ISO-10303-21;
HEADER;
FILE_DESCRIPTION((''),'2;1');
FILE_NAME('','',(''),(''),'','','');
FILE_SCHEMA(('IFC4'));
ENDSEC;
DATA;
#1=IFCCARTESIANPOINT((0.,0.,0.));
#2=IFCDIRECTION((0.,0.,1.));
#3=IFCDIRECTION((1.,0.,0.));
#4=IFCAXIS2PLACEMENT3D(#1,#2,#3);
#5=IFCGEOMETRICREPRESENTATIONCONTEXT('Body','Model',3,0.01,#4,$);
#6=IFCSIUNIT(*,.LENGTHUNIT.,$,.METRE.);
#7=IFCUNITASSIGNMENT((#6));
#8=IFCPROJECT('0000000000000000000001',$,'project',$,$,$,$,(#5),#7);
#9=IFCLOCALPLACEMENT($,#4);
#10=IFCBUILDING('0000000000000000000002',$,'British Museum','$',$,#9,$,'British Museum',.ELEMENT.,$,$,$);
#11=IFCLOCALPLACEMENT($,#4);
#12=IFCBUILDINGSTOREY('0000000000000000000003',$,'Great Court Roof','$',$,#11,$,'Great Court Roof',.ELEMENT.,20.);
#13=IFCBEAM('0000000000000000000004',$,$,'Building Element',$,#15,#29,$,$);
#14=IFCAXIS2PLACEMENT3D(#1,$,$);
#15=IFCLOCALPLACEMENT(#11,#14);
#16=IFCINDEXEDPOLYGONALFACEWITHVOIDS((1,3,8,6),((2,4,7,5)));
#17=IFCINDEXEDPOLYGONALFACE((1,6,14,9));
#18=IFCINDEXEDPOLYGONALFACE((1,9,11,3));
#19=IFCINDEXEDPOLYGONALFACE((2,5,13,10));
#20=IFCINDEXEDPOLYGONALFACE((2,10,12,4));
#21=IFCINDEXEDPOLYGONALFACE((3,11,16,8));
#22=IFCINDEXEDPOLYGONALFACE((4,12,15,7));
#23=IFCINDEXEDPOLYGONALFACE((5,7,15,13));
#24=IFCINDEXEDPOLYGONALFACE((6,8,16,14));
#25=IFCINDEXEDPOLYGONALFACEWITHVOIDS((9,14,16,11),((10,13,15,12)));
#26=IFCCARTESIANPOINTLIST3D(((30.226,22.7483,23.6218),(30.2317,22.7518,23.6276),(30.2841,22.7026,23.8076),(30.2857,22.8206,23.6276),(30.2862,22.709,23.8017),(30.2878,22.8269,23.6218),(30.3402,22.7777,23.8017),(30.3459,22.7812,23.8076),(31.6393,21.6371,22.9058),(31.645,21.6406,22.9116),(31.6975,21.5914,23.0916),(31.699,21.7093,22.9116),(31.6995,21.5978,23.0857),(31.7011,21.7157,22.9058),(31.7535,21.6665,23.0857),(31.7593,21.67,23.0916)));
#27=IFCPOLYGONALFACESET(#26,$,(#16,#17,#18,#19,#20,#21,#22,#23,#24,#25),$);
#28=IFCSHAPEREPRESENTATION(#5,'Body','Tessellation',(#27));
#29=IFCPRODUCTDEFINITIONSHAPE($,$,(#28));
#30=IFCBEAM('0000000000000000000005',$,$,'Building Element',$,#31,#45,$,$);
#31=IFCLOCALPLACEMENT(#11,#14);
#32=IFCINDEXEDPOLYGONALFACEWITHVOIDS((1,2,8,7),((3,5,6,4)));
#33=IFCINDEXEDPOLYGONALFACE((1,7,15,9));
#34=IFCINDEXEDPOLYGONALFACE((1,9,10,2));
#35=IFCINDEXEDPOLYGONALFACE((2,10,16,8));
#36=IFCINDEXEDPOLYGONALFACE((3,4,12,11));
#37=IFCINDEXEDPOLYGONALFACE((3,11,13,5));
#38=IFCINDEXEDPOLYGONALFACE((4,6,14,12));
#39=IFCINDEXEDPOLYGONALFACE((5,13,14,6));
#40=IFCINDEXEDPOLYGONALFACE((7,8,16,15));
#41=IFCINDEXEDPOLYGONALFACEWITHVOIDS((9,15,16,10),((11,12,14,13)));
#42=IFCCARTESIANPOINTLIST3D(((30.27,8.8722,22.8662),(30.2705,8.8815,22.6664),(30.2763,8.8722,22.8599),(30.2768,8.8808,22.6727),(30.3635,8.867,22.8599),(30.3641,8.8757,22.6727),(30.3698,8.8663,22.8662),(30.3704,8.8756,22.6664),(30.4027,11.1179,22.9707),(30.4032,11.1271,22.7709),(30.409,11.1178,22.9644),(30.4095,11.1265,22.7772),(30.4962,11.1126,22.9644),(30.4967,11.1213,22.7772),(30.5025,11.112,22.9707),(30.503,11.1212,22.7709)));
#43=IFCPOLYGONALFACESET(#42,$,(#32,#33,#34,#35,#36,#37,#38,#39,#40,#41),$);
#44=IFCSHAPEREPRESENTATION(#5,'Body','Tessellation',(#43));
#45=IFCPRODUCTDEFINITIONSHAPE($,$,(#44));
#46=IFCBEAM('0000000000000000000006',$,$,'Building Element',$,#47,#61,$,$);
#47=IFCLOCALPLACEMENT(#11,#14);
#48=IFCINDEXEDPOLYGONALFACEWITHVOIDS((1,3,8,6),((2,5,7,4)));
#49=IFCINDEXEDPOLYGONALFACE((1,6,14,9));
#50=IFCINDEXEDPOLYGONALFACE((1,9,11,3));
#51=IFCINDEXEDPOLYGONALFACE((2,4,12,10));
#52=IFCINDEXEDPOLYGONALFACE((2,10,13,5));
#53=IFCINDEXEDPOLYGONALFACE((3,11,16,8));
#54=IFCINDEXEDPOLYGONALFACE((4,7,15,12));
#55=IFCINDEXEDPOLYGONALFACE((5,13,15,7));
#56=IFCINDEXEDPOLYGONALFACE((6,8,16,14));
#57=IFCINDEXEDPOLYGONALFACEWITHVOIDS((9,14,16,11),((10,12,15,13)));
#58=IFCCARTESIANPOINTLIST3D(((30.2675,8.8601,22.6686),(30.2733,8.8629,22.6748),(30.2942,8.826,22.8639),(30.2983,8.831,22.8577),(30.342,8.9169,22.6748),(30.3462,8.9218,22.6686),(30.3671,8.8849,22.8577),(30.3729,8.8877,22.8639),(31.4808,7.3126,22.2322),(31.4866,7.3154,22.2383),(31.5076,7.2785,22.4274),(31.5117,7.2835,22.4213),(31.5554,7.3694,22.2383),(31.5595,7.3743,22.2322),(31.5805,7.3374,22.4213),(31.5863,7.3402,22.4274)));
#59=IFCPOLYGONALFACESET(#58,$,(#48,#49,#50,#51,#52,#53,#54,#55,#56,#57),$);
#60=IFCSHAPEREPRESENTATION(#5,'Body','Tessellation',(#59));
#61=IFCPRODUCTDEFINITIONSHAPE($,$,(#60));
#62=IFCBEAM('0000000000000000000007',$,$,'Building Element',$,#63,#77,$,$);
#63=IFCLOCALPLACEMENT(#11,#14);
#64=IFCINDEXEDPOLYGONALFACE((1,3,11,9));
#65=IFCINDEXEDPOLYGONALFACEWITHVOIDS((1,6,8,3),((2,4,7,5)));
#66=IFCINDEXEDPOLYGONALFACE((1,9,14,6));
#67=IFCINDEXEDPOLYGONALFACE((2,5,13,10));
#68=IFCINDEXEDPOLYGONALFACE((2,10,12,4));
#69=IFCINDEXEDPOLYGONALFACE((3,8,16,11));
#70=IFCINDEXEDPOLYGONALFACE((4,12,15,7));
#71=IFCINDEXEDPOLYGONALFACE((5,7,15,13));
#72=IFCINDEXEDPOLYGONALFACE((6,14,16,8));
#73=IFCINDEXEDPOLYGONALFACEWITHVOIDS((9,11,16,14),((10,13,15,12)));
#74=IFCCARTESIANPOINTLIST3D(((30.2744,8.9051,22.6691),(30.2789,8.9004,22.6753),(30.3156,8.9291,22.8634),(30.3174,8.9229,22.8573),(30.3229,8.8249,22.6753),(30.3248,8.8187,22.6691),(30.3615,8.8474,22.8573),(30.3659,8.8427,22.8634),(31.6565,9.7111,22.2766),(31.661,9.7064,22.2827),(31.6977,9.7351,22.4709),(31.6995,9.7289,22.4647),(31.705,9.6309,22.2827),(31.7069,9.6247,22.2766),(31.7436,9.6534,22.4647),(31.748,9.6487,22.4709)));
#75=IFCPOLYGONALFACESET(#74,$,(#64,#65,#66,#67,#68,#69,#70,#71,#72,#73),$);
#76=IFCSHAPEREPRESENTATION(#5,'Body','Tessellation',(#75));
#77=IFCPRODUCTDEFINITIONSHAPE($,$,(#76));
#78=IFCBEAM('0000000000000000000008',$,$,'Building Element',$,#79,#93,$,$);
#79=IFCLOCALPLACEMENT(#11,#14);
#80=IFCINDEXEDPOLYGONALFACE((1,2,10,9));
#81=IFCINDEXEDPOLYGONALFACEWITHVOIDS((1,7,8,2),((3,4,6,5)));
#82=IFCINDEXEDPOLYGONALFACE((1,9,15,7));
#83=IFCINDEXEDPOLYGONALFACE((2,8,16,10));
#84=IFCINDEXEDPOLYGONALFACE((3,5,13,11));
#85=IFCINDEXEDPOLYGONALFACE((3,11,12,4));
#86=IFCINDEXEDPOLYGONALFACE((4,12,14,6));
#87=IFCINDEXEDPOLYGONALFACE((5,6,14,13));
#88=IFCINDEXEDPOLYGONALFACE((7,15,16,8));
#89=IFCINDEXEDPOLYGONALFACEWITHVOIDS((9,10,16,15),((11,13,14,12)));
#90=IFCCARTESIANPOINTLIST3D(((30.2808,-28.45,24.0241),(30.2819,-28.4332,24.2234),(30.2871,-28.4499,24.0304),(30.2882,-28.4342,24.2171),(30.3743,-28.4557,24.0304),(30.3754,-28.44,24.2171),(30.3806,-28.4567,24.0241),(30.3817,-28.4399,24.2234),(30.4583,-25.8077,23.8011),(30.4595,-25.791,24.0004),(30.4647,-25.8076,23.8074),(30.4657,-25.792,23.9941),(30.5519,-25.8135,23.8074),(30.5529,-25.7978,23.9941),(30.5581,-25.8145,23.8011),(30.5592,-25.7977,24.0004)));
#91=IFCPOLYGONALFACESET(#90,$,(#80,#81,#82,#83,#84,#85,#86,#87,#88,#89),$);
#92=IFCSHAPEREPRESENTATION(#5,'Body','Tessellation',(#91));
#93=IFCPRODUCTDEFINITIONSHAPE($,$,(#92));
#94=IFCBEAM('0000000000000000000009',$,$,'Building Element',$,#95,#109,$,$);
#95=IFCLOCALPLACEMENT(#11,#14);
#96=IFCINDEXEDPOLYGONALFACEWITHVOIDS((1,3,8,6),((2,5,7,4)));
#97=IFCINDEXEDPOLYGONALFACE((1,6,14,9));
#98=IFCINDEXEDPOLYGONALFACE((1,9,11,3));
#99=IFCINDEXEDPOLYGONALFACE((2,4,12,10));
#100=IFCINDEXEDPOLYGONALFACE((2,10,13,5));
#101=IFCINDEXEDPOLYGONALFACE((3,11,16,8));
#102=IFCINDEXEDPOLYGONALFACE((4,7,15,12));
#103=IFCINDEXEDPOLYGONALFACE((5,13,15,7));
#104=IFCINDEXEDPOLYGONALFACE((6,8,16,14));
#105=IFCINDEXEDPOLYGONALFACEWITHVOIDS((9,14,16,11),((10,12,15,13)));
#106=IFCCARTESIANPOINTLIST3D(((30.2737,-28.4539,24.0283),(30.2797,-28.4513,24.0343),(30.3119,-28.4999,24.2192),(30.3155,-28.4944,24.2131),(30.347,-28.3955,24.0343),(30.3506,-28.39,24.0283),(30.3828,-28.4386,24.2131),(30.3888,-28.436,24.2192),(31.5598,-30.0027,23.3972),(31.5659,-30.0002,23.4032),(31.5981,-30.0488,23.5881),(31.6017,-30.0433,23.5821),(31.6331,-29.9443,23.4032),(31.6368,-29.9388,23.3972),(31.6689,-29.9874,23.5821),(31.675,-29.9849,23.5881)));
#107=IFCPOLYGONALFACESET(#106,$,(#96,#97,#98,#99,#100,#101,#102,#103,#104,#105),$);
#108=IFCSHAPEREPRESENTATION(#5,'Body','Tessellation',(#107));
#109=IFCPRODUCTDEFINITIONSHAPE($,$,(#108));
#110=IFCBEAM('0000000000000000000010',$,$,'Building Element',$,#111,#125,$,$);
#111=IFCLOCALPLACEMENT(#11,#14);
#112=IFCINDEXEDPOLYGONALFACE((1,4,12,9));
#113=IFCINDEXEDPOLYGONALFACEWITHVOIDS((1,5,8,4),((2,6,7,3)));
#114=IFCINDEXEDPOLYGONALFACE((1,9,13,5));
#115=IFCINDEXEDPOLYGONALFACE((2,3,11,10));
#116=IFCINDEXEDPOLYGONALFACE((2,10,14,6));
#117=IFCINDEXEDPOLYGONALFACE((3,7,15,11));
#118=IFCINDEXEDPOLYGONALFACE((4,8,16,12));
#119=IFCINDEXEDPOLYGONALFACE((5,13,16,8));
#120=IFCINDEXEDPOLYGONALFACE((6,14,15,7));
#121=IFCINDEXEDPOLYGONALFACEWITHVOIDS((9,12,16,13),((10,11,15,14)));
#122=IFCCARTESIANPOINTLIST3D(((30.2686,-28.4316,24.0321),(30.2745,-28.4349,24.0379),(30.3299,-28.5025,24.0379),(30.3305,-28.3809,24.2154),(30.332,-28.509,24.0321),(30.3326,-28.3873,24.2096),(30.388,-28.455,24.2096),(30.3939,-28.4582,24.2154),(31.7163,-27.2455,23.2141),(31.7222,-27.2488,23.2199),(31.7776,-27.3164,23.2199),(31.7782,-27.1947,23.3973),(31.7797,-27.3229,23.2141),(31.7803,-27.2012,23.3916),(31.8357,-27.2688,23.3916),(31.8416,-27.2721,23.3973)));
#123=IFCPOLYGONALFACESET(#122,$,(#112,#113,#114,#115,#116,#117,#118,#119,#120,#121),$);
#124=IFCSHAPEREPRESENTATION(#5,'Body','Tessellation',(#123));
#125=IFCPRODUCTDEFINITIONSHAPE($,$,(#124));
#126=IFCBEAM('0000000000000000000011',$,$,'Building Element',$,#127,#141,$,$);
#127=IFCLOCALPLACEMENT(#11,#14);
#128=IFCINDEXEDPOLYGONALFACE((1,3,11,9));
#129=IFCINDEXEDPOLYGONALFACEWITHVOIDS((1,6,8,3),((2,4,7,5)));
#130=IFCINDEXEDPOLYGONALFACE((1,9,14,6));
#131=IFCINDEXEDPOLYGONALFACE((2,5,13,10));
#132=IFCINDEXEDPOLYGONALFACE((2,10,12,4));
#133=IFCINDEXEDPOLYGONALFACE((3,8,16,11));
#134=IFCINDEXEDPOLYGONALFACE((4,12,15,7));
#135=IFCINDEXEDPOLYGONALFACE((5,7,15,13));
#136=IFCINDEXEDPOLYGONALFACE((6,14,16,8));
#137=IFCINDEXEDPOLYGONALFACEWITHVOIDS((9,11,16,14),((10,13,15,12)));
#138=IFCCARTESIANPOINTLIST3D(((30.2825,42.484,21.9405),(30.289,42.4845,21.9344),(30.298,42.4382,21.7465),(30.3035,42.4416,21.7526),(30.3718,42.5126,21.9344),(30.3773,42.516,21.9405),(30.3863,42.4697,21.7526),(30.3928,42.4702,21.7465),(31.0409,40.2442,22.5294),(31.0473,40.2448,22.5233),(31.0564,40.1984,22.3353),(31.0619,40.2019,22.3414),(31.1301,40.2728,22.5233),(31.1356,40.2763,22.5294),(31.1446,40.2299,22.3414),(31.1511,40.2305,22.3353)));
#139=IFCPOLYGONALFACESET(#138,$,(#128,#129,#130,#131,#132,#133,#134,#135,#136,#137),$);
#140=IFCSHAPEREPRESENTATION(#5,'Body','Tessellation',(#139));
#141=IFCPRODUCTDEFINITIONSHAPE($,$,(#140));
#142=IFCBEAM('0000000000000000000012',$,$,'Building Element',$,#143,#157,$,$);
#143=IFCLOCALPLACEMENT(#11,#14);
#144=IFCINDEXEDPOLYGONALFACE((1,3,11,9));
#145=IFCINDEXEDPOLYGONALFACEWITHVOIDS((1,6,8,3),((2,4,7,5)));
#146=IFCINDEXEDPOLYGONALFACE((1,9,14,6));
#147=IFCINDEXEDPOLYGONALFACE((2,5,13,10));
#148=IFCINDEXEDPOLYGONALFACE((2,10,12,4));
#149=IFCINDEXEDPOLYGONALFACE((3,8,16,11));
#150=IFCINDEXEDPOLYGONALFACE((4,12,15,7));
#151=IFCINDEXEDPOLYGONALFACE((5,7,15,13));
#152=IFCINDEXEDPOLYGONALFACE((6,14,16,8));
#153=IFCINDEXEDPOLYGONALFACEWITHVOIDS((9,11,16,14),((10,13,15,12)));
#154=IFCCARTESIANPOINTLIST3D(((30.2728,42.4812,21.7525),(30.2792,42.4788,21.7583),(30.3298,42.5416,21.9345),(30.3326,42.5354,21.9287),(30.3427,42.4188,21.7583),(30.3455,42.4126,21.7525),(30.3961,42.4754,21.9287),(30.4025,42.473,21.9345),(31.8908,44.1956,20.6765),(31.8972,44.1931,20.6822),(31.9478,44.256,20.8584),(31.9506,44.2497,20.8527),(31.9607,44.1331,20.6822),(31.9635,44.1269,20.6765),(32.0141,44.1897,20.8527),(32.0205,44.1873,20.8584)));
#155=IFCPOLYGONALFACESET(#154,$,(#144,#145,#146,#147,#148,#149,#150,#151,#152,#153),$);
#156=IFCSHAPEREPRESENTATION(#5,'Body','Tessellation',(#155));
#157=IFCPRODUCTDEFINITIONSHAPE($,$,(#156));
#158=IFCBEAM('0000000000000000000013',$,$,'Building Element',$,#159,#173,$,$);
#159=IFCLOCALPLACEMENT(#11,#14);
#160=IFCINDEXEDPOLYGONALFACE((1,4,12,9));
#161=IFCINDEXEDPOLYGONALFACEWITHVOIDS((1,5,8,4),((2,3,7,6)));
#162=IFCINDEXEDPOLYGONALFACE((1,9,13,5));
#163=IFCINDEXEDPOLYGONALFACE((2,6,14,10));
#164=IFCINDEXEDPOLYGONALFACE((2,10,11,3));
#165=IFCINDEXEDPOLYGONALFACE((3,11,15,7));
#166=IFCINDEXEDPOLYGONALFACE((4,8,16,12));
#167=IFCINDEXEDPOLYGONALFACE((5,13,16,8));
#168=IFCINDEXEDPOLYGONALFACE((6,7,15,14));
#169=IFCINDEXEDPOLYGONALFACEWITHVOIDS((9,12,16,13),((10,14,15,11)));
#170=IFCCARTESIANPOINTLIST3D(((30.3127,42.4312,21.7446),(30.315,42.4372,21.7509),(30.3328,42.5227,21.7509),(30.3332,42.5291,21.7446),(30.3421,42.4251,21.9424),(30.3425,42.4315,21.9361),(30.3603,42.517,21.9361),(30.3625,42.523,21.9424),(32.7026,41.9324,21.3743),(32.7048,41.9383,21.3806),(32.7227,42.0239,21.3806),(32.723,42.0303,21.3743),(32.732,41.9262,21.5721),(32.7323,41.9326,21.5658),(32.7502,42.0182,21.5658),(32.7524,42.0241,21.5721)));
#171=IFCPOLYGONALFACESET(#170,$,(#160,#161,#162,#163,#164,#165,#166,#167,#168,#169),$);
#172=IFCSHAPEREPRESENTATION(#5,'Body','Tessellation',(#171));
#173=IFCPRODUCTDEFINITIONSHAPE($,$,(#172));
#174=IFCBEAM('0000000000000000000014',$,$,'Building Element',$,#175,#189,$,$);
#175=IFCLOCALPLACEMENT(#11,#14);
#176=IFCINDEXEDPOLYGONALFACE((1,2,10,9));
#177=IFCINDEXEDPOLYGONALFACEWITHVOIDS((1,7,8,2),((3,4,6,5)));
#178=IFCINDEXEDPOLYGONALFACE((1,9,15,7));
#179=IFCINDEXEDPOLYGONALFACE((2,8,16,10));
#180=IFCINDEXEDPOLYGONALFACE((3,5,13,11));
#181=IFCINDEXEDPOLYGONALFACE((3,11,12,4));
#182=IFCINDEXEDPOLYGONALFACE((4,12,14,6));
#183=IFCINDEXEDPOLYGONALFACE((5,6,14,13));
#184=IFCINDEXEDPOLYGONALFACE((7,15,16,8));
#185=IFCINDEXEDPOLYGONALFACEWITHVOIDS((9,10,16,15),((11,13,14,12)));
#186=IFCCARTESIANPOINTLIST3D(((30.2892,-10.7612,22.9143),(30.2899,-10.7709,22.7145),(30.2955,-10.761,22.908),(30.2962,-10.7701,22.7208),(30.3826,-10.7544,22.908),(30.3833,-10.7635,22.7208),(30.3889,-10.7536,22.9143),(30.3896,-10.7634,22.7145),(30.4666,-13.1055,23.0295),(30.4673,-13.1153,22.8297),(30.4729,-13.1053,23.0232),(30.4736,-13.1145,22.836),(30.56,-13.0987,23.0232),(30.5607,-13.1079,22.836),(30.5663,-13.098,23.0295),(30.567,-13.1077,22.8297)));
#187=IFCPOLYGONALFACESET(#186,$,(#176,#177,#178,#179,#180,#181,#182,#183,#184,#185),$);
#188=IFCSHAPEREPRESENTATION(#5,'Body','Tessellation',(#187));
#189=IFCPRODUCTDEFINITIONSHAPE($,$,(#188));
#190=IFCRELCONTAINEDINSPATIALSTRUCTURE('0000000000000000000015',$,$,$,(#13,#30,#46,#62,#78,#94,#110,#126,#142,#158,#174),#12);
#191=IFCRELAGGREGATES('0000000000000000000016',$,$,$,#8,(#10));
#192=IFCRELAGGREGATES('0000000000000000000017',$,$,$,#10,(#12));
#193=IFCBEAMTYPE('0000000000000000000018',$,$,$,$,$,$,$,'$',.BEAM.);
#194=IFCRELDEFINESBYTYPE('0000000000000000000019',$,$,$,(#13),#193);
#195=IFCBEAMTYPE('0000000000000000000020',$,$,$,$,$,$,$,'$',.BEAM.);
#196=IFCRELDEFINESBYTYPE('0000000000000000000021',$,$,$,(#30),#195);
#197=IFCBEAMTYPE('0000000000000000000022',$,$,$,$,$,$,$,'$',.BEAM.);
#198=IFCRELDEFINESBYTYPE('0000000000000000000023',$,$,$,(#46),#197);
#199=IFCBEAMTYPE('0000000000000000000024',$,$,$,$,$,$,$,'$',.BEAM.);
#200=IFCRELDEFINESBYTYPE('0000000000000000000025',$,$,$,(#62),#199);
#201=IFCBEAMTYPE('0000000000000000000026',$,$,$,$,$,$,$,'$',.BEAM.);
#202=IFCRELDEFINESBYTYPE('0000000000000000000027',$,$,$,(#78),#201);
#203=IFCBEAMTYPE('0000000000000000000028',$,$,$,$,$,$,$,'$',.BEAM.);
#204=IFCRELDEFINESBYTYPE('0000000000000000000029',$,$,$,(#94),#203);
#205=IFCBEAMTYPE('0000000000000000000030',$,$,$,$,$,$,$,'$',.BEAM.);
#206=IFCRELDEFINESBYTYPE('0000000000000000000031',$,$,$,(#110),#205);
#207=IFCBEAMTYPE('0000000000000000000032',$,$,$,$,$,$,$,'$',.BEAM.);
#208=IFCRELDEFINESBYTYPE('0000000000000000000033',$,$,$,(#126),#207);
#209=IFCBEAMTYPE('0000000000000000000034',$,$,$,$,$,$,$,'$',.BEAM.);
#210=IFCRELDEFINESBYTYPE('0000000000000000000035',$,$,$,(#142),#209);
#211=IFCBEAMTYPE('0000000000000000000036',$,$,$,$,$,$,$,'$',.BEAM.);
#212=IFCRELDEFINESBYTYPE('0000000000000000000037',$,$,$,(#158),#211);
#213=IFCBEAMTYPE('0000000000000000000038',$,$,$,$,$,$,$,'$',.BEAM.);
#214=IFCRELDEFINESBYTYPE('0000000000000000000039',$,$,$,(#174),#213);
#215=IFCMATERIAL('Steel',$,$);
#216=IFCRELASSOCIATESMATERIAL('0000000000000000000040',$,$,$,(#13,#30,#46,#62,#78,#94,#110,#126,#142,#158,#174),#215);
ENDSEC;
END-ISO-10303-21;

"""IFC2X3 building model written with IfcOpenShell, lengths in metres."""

from ifc_helpers import new_model, si_unit, frame, origin_with_axes, origin_2d, place, context, project, spatial, hollow_rectangle, extrude, material, type_object, element, save


model = new_model("IFC2X3")

# Units and contexts
model_context = context("Model", 3, precision=0.01, world=origin_with_axes(), identifier="Body")
ifc_project = project(units=[si_unit("LENGTHUNIT", "METRE")], contexts=[model_context])

# Building, storey
building_placement = place(None, origin_with_axes())
building = spatial("IfcBuilding", under=ifc_project, at=building_placement, Name="British Museum", Description="$", LongName="British Museum", CompositionType="ELEMENT")
storey_placement = place(None, origin_with_axes())
storey = spatial("IfcBuildingStorey", under=building, at=storey_placement, Name="Great Court Roof", Description="$", LongName="Great Court Roof", CompositionType="ELEMENT", Elevation=20.0)

# Beams
ifc_material = material(Name="Steel")
beam_type_1 = type_object("IfcBeamType", ElementType="$", PredefinedType="BEAM")
beam_1_placement = place(None, origin_with_axes())
element("IfcBeam", 1, at=beam_1_placement, inside=storey, type_object=beam_type_1, material=ifc_material, Description="Building Element", context=model_context, shape_type="SweptSolid", body=[
    extrude(hollow_rectangle(XDim=0.1, YDim=0.2, WallThickness=0.0063, InnerFilletRadius=-0.0063, OuterFilletRadius=0.0, at=origin_2d()), frame((30.2859, 22.7648, 23.7147), z_axis=(0.730324, -0.574223, -0.369994), x_axis=(0.618086, 0.786111, 0.0)), (0.0, 0.0, 1.0), 1.9352),
])
beam_type_2 = type_object("IfcBeamType", ElementType="$", PredefinedType="BEAM")
beam_2_placement = place(None, origin_with_axes())
element("IfcBeam", 2, at=beam_2_placement, inside=storey, type_object=beam_type_2, material=ifc_material, Description="Building Element", context=model_context, shape_type="SweptSolid", body=[
    extrude(hollow_rectangle(XDim=0.1, YDim=0.2, WallThickness=0.0063, InnerFilletRadius=-0.0063, OuterFilletRadius=0.0, at=origin_2d()), frame((30.3202, 8.8739, 22.7663), z_axis=(0.05891, 0.997183, 0.046437), x_axis=(-0.99826, 0.058973, 0.0)), (0.0, 0.0, 1.0), 2.252),
])
beam_type_3 = type_object("IfcBeamType", ElementType="$", PredefinedType="BEAM")
beam_3_placement = place(None, origin_with_axes())
element("IfcBeam", 3, at=beam_3_placement, inside=storey, type_object=beam_type_3, material=ifc_material, Description="Building Element", context=model_context, shape_type="SweptSolid", body=[
    extrude(hollow_rectangle(XDim=0.1, YDim=0.2, WallThickness=0.0063, InnerFilletRadius=-0.0063, OuterFilletRadius=0.0, at=origin_2d()), frame((30.3202, 8.8739, 22.7663), z_axis=(0.602369, -0.768247, -0.216676), x_axis=(0.786941, 0.617028, 0.0)), (0.0, 0.0, 1.0), 2.0143),
])
beam_type_4 = type_object("IfcBeamType", ElementType="$", PredefinedType="BEAM")
beam_4_placement = place(None, origin_with_axes())
element("IfcBeam", 4, at=beam_4_placement, inside=storey, type_object=beam_type_4, material=ifc_material, Description="Building Element", context=model_context, shape_type="SweptSolid", body=[
    extrude(hollow_rectangle(XDim=0.1, YDim=0.2, WallThickness=0.0063, InnerFilletRadius=-0.0063, OuterFilletRadius=0.0, at=origin_2d()), frame((30.3202, 8.8739, 22.7663), z_axis=(0.838966, 0.489248, -0.238269), x_axis=(-0.503756, 0.863846, 0.0)), (0.0, 0.0, 1.0), 1.6474),
])
beam_type_5 = type_object("IfcBeamType", ElementType="$", PredefinedType="BEAM")
beam_5_placement = place(None, origin_with_axes())
element("IfcBeam", 5, at=beam_5_placement, inside=storey, type_object=beam_type_5, material=ifc_material, Description="Building Element", context=model_context, shape_type="SweptSolid", body=[
    extrude(hollow_rectangle(XDim=0.1, YDim=0.2, WallThickness=0.0063, InnerFilletRadius=-0.0063, OuterFilletRadius=0.0, at=origin_2d()), frame((30.3313, -28.4449, 24.1237), z_axis=(0.066805, 0.994231, -0.083912), x_axis=(-0.99775, 0.067042, 0.0)), (0.0, 0.0, 1.0), 2.6575),
])
beam_type_6 = type_object("IfcBeamType", ElementType="$", PredefinedType="BEAM")
beam_6_placement = place(None, origin_with_axes())
element("IfcBeam", 6, at=beam_6_placement, inside=storey, type_object=beam_type_6, material=ifc_material, Description="Building Element", context=model_context, shape_type="SweptSolid", body=[
    extrude(hollow_rectangle(XDim=0.1, YDim=0.2, WallThickness=0.0063, InnerFilletRadius=-0.0063, OuterFilletRadius=0.0, at=origin_2d()), frame((30.3313, -28.4449, 24.1237), z_axis=(0.609598, -0.734112, -0.299116), x_axis=(0.769334, 0.638847, 0.0)), (0.0, 0.0, 1.0), 2.1099),
])
beam_type_7 = type_object("IfcBeamType", ElementType="$", PredefinedType="BEAM")
beam_7_placement = place(None, origin_with_axes())
element("IfcBeam", 7, at=beam_7_placement, inside=storey, type_object=beam_type_7, material=ifc_material, Description="Building Element", context=model_context, shape_type="SweptSolid", body=[
    extrude(hollow_rectangle(XDim=0.1, YDim=0.2, WallThickness=0.0063, InnerFilletRadius=-0.0063, OuterFilletRadius=0.0, at=origin_2d()), frame((30.3313, -28.4449, 24.1237), z_axis=(0.708777, 0.580722, -0.400496), x_axis=(-0.63377, 0.773522, 0.0)), (0.0, 0.0, 1.0), 2.0425),
])
beam_type_8 = type_object("IfcBeamType", ElementType="$", PredefinedType="BEAM")
beam_8_placement = place(None, origin_with_axes())
element("IfcBeam", 8, at=beam_8_placement, inside=storey, type_object=beam_type_8, material=ifc_material, Description="Building Element", context=model_context, shape_type="SweptSolid", body=[
    extrude(hollow_rectangle(XDim=0.1, YDim=0.2, WallThickness=0.0063, InnerFilletRadius=-0.0063, OuterFilletRadius=0.0, at=origin_2d()), frame((30.3376, 42.4771, 21.8435), z_axis=(0.311197, -0.919111, 0.241644), x_axis=(0.94718, 0.320701, 0.0)), (0.0, 0.0, 1.0), 2.4369),
])
beam_type_9 = type_object("IfcBeamType", ElementType="$", PredefinedType="BEAM")
beam_9_placement = place(None, origin_with_axes())
element("IfcBeam", 9, at=beam_9_placement, inside=storey, type_object=beam_type_9, material=ifc_material, Description="Building Element", context=model_context, shape_type="SweptSolid", body=[
    extrude(hollow_rectangle(XDim=0.1, YDim=0.2, WallThickness=0.0063, InnerFilletRadius=-0.0063, OuterFilletRadius=0.0, at=origin_2d()), frame((30.3376, 42.4771, 21.8435), z_axis=(0.624401, 0.661579, -0.415255), x_axis=(-0.727246, 0.686377, 0.0)), (0.0, 0.0, 1.0), 2.5913),
])
beam_type_10 = type_object("IfcBeamType", ElementType="$", PredefinedType="BEAM")
beam_10_placement = place(None, origin_with_axes())
element("IfcBeam", 10, at=beam_10_placement, inside=storey, type_object=beam_type_10, material=ifc_material, Description="Building Element", context=model_context, shape_type="SweptSolid", body=[
    extrude(hollow_rectangle(XDim=0.1, YDim=0.2, WallThickness=0.0063, InnerFilletRadius=-0.0063, OuterFilletRadius=0.0, at=origin_2d()), frame((30.3376, 42.4771, 21.8435), z_axis=(0.967831, -0.202024, -0.149965), x_axis=(0.204335, 0.978901, 0.0)), (0.0, 0.0, 1.0), 2.4693),
])
beam_type_11 = type_object("IfcBeamType", ElementType="$", PredefinedType="BEAM")
beam_11_placement = place(None, origin_with_axes())
element("IfcBeam", 11, at=beam_11_placement, inside=storey, type_object=beam_type_11, material=ifc_material, Description="Building Element", context=model_context, shape_type="SweptSolid", body=[
    extrude(hollow_rectangle(XDim=0.1, YDim=0.2, WallThickness=0.0063, InnerFilletRadius=-0.0063, OuterFilletRadius=0.0, at=origin_2d()), frame((30.3394, -10.7623, 22.8144), z_axis=(0.075357, -0.995955, 0.048937), x_axis=(0.99715, 0.075447, 0.0)), (0.0, 0.0, 1.0), 2.3539),
])

save(model, "model.ifc")
